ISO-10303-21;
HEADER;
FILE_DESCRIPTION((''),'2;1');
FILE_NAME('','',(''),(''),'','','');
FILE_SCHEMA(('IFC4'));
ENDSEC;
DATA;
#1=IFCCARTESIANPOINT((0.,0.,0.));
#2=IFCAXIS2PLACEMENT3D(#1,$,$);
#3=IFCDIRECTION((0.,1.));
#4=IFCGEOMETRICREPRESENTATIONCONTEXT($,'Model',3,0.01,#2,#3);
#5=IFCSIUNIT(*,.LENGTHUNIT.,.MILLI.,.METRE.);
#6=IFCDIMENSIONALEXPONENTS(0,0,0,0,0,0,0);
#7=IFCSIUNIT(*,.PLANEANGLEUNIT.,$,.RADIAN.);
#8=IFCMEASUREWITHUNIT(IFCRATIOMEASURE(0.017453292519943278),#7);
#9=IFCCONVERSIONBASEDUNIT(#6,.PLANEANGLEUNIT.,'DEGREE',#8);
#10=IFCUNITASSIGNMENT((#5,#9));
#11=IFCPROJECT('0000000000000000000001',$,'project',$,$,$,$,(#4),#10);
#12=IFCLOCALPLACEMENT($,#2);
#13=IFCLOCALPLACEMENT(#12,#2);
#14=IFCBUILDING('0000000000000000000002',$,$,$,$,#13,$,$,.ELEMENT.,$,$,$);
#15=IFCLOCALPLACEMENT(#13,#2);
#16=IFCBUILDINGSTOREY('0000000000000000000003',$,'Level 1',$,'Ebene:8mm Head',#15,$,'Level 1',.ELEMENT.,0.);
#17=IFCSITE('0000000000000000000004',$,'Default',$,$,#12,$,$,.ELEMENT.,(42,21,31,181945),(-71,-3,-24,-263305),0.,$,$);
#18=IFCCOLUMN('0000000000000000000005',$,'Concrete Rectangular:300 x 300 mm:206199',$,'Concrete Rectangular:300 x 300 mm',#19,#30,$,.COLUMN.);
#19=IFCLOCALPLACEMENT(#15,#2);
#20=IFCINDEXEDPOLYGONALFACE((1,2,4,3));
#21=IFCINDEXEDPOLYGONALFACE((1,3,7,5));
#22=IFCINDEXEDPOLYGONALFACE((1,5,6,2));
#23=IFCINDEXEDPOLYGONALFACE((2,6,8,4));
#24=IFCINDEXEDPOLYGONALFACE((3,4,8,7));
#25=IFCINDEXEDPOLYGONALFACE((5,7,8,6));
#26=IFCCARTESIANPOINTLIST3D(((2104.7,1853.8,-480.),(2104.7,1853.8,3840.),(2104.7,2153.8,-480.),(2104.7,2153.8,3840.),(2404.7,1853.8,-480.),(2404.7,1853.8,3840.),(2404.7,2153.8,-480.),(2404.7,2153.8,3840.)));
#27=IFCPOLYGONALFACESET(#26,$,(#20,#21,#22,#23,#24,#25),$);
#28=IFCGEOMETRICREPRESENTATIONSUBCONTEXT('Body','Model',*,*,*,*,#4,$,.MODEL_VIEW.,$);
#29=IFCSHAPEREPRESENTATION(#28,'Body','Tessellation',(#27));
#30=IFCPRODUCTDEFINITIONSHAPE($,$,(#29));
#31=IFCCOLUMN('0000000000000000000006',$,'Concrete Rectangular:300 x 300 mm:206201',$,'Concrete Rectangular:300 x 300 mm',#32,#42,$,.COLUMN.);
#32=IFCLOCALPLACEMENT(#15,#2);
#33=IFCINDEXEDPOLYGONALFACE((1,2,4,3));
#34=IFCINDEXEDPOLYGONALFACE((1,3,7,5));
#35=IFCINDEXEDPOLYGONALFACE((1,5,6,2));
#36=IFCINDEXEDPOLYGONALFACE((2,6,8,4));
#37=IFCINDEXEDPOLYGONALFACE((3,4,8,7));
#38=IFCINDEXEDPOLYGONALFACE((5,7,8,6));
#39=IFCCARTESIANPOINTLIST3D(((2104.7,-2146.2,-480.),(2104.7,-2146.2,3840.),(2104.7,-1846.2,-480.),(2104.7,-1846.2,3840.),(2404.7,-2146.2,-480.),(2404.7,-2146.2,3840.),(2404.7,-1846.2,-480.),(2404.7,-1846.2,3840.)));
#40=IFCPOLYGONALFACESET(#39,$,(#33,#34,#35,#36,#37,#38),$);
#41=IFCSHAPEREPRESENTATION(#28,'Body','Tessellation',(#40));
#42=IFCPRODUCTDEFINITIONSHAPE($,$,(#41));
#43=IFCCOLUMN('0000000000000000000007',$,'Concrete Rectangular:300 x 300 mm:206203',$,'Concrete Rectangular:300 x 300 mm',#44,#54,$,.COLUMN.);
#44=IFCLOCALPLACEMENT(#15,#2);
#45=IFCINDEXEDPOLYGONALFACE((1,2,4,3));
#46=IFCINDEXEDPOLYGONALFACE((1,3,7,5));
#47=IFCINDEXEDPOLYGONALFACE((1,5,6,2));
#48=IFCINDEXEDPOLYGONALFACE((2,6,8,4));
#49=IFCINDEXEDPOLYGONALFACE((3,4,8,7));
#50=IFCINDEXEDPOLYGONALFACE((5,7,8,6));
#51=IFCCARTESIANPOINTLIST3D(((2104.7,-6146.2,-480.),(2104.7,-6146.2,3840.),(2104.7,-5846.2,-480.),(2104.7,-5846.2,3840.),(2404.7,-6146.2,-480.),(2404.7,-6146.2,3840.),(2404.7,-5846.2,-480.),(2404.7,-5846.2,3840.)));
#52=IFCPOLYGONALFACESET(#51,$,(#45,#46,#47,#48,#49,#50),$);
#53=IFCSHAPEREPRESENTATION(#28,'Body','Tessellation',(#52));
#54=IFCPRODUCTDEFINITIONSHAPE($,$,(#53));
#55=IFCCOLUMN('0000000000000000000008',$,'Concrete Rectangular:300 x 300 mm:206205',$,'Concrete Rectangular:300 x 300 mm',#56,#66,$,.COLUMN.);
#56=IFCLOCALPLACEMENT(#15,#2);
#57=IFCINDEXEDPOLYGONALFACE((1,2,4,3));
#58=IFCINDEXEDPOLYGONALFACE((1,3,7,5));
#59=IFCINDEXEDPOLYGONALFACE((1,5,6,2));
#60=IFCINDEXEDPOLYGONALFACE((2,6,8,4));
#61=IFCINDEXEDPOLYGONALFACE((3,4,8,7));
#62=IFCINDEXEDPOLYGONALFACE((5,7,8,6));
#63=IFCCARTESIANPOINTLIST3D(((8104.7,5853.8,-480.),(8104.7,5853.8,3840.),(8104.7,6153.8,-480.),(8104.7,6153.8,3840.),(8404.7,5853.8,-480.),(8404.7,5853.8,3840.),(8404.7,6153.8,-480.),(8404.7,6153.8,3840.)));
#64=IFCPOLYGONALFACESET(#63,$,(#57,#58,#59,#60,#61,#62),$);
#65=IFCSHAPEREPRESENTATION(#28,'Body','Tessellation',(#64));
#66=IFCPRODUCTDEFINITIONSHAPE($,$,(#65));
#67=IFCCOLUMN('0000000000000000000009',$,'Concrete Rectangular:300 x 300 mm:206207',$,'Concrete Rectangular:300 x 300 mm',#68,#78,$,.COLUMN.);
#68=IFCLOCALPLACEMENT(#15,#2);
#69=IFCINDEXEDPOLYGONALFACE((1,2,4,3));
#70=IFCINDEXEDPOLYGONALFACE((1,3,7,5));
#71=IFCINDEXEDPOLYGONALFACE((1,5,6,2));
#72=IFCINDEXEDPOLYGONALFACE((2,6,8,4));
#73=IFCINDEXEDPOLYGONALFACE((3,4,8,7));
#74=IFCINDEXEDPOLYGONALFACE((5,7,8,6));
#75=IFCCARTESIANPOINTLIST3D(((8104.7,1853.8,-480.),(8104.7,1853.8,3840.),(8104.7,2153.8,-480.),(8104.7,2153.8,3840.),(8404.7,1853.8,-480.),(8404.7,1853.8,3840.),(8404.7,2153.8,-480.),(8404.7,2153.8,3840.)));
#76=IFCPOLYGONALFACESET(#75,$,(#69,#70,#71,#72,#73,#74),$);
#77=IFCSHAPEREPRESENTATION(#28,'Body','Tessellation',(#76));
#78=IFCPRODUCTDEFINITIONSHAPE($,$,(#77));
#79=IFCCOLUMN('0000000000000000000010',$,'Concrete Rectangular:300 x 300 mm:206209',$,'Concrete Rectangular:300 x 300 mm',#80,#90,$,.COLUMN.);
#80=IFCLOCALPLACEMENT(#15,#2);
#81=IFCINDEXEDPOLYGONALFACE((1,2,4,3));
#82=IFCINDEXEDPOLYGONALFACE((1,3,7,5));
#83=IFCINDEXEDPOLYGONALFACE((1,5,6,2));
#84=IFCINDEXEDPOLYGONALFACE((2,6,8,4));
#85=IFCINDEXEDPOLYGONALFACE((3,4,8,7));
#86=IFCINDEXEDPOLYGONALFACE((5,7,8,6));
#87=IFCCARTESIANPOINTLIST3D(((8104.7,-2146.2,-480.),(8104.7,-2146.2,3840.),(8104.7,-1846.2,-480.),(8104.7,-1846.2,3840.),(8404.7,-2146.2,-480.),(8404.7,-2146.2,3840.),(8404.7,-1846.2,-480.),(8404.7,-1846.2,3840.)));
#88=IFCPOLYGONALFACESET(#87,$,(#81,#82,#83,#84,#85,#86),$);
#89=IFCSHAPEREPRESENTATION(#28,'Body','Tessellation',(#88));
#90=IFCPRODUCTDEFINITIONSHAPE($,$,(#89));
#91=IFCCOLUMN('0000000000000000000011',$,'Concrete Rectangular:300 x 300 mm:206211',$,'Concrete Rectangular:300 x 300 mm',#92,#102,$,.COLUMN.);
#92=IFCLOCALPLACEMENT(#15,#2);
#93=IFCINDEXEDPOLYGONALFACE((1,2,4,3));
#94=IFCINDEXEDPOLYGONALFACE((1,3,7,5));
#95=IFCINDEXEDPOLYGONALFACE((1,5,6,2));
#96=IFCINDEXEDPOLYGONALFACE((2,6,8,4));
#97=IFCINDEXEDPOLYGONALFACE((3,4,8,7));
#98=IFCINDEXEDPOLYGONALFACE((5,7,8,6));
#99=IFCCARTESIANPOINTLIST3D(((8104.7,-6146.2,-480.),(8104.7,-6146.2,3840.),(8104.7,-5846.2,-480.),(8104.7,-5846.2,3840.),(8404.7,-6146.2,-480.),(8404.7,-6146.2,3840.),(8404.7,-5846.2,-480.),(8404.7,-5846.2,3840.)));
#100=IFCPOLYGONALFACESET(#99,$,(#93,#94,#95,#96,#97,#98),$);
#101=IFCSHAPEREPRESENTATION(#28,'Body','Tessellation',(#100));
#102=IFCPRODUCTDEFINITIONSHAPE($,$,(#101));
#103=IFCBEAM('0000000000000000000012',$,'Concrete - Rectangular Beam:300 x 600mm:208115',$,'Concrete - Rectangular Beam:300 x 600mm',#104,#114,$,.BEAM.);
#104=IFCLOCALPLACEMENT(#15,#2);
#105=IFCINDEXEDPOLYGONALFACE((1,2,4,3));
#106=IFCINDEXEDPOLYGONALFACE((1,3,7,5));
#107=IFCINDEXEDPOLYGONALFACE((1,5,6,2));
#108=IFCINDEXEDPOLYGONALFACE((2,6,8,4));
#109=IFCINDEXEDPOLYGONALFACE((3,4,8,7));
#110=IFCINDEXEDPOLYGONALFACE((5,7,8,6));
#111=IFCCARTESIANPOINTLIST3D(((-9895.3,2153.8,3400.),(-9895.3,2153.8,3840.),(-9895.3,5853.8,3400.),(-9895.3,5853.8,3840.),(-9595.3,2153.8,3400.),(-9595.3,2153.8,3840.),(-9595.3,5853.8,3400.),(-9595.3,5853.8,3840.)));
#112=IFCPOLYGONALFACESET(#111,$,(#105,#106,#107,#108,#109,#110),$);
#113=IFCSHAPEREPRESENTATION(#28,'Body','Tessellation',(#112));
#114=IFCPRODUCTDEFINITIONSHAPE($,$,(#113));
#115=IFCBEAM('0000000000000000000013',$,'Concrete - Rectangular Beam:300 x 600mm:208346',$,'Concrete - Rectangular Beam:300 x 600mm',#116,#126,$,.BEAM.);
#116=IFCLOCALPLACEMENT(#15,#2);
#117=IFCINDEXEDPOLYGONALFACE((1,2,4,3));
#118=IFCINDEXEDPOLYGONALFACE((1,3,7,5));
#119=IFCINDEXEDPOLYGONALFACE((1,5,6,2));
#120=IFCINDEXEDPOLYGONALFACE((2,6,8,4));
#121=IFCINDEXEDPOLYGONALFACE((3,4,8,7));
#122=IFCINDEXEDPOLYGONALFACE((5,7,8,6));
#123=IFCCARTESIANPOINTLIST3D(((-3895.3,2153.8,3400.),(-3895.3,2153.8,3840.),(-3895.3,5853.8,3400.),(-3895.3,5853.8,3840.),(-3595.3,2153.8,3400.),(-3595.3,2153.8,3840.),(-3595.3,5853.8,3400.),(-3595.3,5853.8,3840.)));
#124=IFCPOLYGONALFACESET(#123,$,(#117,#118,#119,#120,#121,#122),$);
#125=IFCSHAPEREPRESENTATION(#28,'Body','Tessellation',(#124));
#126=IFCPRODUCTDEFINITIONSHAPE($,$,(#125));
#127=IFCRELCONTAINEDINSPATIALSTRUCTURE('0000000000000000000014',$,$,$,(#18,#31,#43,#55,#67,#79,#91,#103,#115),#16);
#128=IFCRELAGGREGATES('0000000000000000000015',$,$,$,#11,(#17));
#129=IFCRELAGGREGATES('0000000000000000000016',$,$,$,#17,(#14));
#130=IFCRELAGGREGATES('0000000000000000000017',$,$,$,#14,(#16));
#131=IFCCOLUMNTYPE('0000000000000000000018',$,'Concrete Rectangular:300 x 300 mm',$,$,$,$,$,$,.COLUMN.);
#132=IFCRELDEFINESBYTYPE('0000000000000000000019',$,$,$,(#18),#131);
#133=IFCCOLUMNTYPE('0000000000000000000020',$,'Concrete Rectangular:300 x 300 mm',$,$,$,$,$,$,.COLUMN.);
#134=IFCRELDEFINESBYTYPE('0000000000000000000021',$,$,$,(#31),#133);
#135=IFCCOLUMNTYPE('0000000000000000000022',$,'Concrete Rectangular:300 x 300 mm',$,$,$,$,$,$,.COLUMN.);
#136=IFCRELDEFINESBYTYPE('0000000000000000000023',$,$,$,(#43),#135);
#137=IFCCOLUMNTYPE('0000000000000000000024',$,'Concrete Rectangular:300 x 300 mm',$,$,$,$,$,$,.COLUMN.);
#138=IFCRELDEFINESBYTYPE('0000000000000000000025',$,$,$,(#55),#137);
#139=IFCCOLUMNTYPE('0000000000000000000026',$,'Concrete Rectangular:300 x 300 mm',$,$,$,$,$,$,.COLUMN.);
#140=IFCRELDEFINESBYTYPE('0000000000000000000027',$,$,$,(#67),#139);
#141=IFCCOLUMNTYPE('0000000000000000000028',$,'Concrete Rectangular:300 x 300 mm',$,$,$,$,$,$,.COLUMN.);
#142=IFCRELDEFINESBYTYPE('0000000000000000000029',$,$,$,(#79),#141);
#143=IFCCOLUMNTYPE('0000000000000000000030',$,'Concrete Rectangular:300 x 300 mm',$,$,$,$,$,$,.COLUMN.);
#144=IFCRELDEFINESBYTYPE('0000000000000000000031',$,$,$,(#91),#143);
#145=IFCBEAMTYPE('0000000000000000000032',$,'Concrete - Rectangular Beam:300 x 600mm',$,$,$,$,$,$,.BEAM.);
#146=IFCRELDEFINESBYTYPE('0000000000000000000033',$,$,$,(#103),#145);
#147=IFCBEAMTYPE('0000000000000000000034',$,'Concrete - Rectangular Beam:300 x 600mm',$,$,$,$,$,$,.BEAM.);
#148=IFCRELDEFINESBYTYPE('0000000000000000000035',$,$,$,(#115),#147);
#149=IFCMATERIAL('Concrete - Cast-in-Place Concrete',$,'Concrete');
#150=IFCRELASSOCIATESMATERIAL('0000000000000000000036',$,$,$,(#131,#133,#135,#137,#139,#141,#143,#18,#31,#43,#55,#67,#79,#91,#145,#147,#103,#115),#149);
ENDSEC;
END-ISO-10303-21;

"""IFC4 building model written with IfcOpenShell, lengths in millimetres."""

from ifc_helpers import new_model, entity, si_unit, converted_unit, direction, frame, frame_2d, origin, origin_2d_with_axis, place, context, subcontext, project, spatial, polyline, segment, composite_curve, rectangle, outline, extrude, source, transform, mapped, material, material_profile, profile_set, profile_usage, type_object, type_shapes, element, save


model = new_model("IFC4")

# Units and contexts
model_context = context("Model", 3, precision=0.01, world=origin(), true_north=direction((0.0, 1.0)))
body_context = subcontext(model_context, "Body", "Model", "MODEL_VIEW")
ifc_project = project(units=[si_unit("LENGTHUNIT", "METRE", prefix="MILLI"), converted_unit("PLANEANGLEUNIT", "DEGREE", entity("IfcRatioMeasure", 0.017453292519943278), si_unit("PLANEANGLEUNIT", "RADIAN"), dimensions=[0, 0, 0, 0, 0, 0, 0])], contexts=[model_context])

# Site, building, storey
site_placement = place(None, origin())
site = spatial("IfcSite", under=ifc_project, at=site_placement, Name="Default", CompositionType="ELEMENT", RefLatitude=(42, 21, 31, 181945), RefLongitude=(-71, -3, -24, -263305), RefElevation=0.0)
building_placement = place(site_placement, origin())
building = spatial("IfcBuilding", under=site, at=building_placement, CompositionType="ELEMENT")
storey_placement = place(building_placement, origin())
storey = spatial("IfcBuildingStorey", under=building, at=storey_placement, Name="Level 1", ObjectType="Ebene:8mm Head", LongName="Level 1", CompositionType="ELEMENT", Elevation=0.0)

# Columns
ifc_material_1 = material(Name="Concrete - Cast-in-Place Concrete", Category="Concrete")
ifc_material_profile_1 = material_profile(ifc_material_1, outline(composite_curve([segment(polyline([(150.0, 150.0, 0.0), (150.0, -150.0, 0.0)]), True, "CONTINUOUS"), segment(polyline([(150.0, -150.0, 0.0), (-150.0, -150.0, 0.0)]), True, "CONTINUOUS"), segment(polyline([(-150.0, -150.0, 0.0), (-150.0, 150.0, 0.0)]), True, "CONTINUOUS"), segment(polyline([(-150.0, 150.0, 0.0), (150.0, 150.0, 0.0)]), True, "CONTINUOUS")], self_intersect=False), kind="CURVE"), Name="300 x 300 mm")
ifc_material_profile_2 = material_profile(ifc_material_1, outline(composite_curve([segment(polyline([(150.0, 150.0, 4000.0), (-150.0, 150.0, 4000.0)]), True, "CONTINUOUS"), segment(polyline([(-150.0, 150.0, 4000.0), (-150.0, -150.0, 4000.0)]), True, "CONTINUOUS"), segment(polyline([(-150.0, -150.0, 4000.0), (150.0, -150.0, 4000.0)]), True, "CONTINUOUS"), segment(polyline([(150.0, -150.0, 4000.0), (150.0, 150.0, 4000.0)]), True, "CONTINUOUS")], self_intersect=False), kind="CURVE"), Name="300 x 300 mm")
ifc_profile_set_1 = profile_set([ifc_material_profile_1, ifc_material_profile_2], Name="300 x 300 mm")
ifc_profile_usage_1 = profile_usage(ifc_profile_set_1)
column_type_1 = type_object("IfcColumnType", Name="Concrete Rectangular:300 x 300 mm", PredefinedType="COLUMN", material=ifc_profile_set_1)
shared_shape_1 = source(origin(), body_context, "Body", "SweptSolid", [
    extrude(rectangle(XDim=300.0, YDim=300.0, at=origin_2d_with_axis()), frame((2254.7, 2003.8, -480.0), z_axis=(0.0, 0.0, 1.0), x_axis=(0.0, -1.0, 0.0)), (0.0, 0.0, 1.0), 4320.0),
])
type_shapes(column_type_1, [shared_shape_1])
column_1_placement = place(storey_placement, origin())
element("IfcColumn", 1, at=column_1_placement, inside=storey, type_object=column_type_1, material=ifc_profile_usage_1, Name="Concrete Rectangular:300 x 300 mm:206199", ObjectType="Concrete Rectangular:300 x 300 mm", PredefinedType="COLUMN", context=body_context, shape_type="MappedRepresentation", body=[
    mapped(shared_shape_1, transform((0.0, 0.0, 0.0), scale=1.0)),
])
ifc_profile_usage_2 = profile_usage(ifc_profile_set_1)
column_type_2 = type_object("IfcColumnType", Name="Concrete Rectangular:300 x 300 mm", PredefinedType="COLUMN", material=ifc_profile_set_1)
shared_shape_2 = source(origin(), body_context, "Body", "SweptSolid", [
    extrude(rectangle(XDim=300.0, YDim=300.0, at=origin_2d_with_axis()), frame((2254.7, -1996.2, -480.0), z_axis=(0.0, 0.0, 1.0), x_axis=(0.0, -1.0, 0.0)), (0.0, 0.0, 1.0), 4320.0),
])
type_shapes(column_type_2, [shared_shape_2])
column_2_placement = place(storey_placement, origin())
element("IfcColumn", 2, at=column_2_placement, inside=storey, type_object=column_type_2, material=ifc_profile_usage_2, Name="Concrete Rectangular:300 x 300 mm:206201", ObjectType="Concrete Rectangular:300 x 300 mm", PredefinedType="COLUMN", context=body_context, shape_type="MappedRepresentation", body=[
    mapped(shared_shape_2, transform((0.0, 0.0, 0.0), scale=1.0)),
])
ifc_profile_usage_3 = profile_usage(ifc_profile_set_1)
column_type_3 = type_object("IfcColumnType", Name="Concrete Rectangular:300 x 300 mm", PredefinedType="COLUMN", material=ifc_profile_set_1)
shared_shape_3 = source(origin(), body_context, "Body", "SweptSolid", [
    extrude(rectangle(XDim=300.0, YDim=300.0, at=frame_2d((0.0, 0.0), x_axis=(1.0, 0.0))), frame((2254.7, -5996.2, -480.0), z_axis=(0.0, 0.0, 1.0), x_axis=(0.0, -1.0, 0.0)), (0.0, 0.0, 1.0), 4320.0),
])
type_shapes(column_type_3, [shared_shape_3])
column_3_placement = place(storey_placement, origin())
element("IfcColumn", 3, at=column_3_placement, inside=storey, type_object=column_type_3, material=ifc_profile_usage_3, Name="Concrete Rectangular:300 x 300 mm:206203", ObjectType="Concrete Rectangular:300 x 300 mm", PredefinedType="COLUMN", context=body_context, shape_type="MappedRepresentation", body=[
    mapped(shared_shape_3, transform((0.0, 0.0, 0.0), scale=1.0)),
])
ifc_profile_usage_4 = profile_usage(ifc_profile_set_1)
column_type_4 = type_object("IfcColumnType", Name="Concrete Rectangular:300 x 300 mm", PredefinedType="COLUMN", material=ifc_profile_set_1)
shared_shape_4 = source(origin(), body_context, "Body", "SweptSolid", [
    extrude(rectangle(XDim=300.0, YDim=300.0, at=frame_2d((0.0, 0.0), x_axis=(1.0, 0.0))), frame((8254.7, 6003.8, -480.0), z_axis=(0.0, 0.0, 1.0), x_axis=(0.0, -1.0, 0.0)), (0.0, 0.0, 1.0), 4320.0),
])
type_shapes(column_type_4, [shared_shape_4])
column_4_placement = place(storey_placement, origin())
element("IfcColumn", 4, at=column_4_placement, inside=storey, type_object=column_type_4, material=ifc_profile_usage_4, Name="Concrete Rectangular:300 x 300 mm:206205", ObjectType="Concrete Rectangular:300 x 300 mm", PredefinedType="COLUMN", context=body_context, shape_type="MappedRepresentation", body=[
    mapped(shared_shape_4, transform((0.0, 0.0, 0.0), scale=1.0)),
])
ifc_profile_usage_5 = profile_usage(ifc_profile_set_1)
column_type_5 = type_object("IfcColumnType", Name="Concrete Rectangular:300 x 300 mm", PredefinedType="COLUMN", material=ifc_profile_set_1)
shared_shape_5 = source(origin(), body_context, "Body", "SweptSolid", [
    extrude(rectangle(XDim=300.0, YDim=300.0, at=frame_2d((0.0, 0.0), x_axis=(1.0, 0.0))), frame((8254.7, 2003.8, -480.0), z_axis=(0.0, 0.0, 1.0), x_axis=(0.0, -1.0, 0.0)), (0.0, 0.0, 1.0), 4320.0),
])
type_shapes(column_type_5, [shared_shape_5])
column_5_placement = place(storey_placement, origin())
element("IfcColumn", 5, at=column_5_placement, inside=storey, type_object=column_type_5, material=ifc_profile_usage_5, Name="Concrete Rectangular:300 x 300 mm:206207", ObjectType="Concrete Rectangular:300 x 300 mm", PredefinedType="COLUMN", context=body_context, shape_type="MappedRepresentation", body=[
    mapped(shared_shape_5, transform((0.0, 0.0, 0.0), scale=1.0)),
])
ifc_profile_usage_6 = profile_usage(ifc_profile_set_1)
column_type_6 = type_object("IfcColumnType", Name="Concrete Rectangular:300 x 300 mm", PredefinedType="COLUMN", material=ifc_profile_set_1)
shared_shape_6 = source(origin(), body_context, "Body", "SweptSolid", [
    extrude(rectangle(XDim=300.0, YDim=300.0, at=frame_2d((0.0, 0.0), x_axis=(1.0, 0.0))), frame((8254.7, -1996.2, -480.0), z_axis=(0.0, 0.0, 1.0), x_axis=(0.0, -1.0, 0.0)), (0.0, 0.0, 1.0), 4320.0),
])
type_shapes(column_type_6, [shared_shape_6])
column_6_placement = place(storey_placement, origin())
element("IfcColumn", 6, at=column_6_placement, inside=storey, type_object=column_type_6, material=ifc_profile_usage_6, Name="Concrete Rectangular:300 x 300 mm:206209", ObjectType="Concrete Rectangular:300 x 300 mm", PredefinedType="COLUMN", context=body_context, shape_type="MappedRepresentation", body=[
    mapped(shared_shape_6, transform((0.0, 0.0, 0.0), scale=1.0)),
])
ifc_profile_usage_7 = profile_usage(ifc_profile_set_1)
column_type_7 = type_object("IfcColumnType", Name="Concrete Rectangular:300 x 300 mm", PredefinedType="COLUMN", material=ifc_profile_set_1)
shared_shape_7 = source(origin(), body_context, "Body", "SweptSolid", [
    extrude(rectangle(XDim=300.0, YDim=300.0, at=frame_2d((0.0, 0.0), x_axis=(1.0, 0.0))), frame((8254.7, -5996.2, -480.0), z_axis=(0.0, 0.0, 1.0), x_axis=(0.0, -1.0, 0.0)), (0.0, 0.0, 1.0), 4320.0),
])
type_shapes(column_type_7, [shared_shape_7])
column_7_placement = place(storey_placement, origin())
element("IfcColumn", 7, at=column_7_placement, inside=storey, type_object=column_type_7, material=ifc_profile_usage_7, Name="Concrete Rectangular:300 x 300 mm:206211", ObjectType="Concrete Rectangular:300 x 300 mm", PredefinedType="COLUMN", context=body_context, shape_type="MappedRepresentation", body=[
    mapped(shared_shape_7, transform((0.0, 0.0, 0.0), scale=1.0)),
])

# Beams
ifc_material_profile_3 = material_profile(ifc_material_1, outline(composite_curve([segment(polyline([(-150.0, -300.0, 0.0), (-150.0, 140.0, 0.0)]), True, "CONTINUOUS"), segment(polyline([(-150.0, 140.0, 0.0), (150.0, 140.0, 0.0)]), True, "CONTINUOUS"), segment(polyline([(150.0, 140.0, 0.0), (150.0, -300.0, 0.0)]), True, "CONTINUOUS"), segment(polyline([(150.0, -300.0, 0.0), (-150.0, -300.0, 0.0)]), True, "CONTINUOUS")], self_intersect=False), kind="CURVE"), Name="300 x 600mm")
ifc_material_profile_4 = material_profile(ifc_material_1, outline(composite_curve([segment(polyline([(1850.0, -150.0, -300.0), (1850.0, -150.0, 300.0)]), True, "CONTINUOUS"), segment(polyline([(1850.0, -150.0, 300.0), (-1850.0, -150.0, 300.0)]), True, "CONTINUOUS"), segment(polyline([(-1850.0, -150.0, 300.0), (-1850.0, -150.0, -300.0)]), True, "CONTINUOUS"), segment(polyline([(-1850.0, -150.0, -300.0), (1850.0, -150.0, -300.0)]), True, "CONTINUOUS")], self_intersect=False), kind="CURVE"), Name="300 x 600mm")
ifc_profile_set_2 = profile_set([ifc_material_profile_3, ifc_material_profile_4], Name="300 x 600mm")
ifc_profile_usage_8 = profile_usage(ifc_profile_set_2, cardinal=8)
beam_type_1 = type_object("IfcBeamType", Name="Concrete - Rectangular Beam:300 x 600mm", PredefinedType="BEAM", material=ifc_profile_set_2)
shared_shape_8 = source(origin(), body_context, "Body", "SweptSolid", [
    extrude(rectangle(XDim=440.0, YDim=300.0, at=frame_2d((0.0, 0.0), x_axis=(0.0, 1.0))), frame((-9745.3, 5853.8, 3620.0), z_axis=(0.0, -1.0, 0.0), x_axis=(-1.0, 0.0, 0.0)), (0.0, 0.0, 1.0), 3700.0),
])
type_shapes(beam_type_1, [shared_shape_8])
beam_1_placement = place(storey_placement, origin())
element("IfcBeam", 8, at=beam_1_placement, inside=storey, type_object=beam_type_1, material=ifc_profile_usage_8, Name="Concrete - Rectangular Beam:300 x 600mm:208115", ObjectType="Concrete - Rectangular Beam:300 x 600mm", PredefinedType="BEAM", context=body_context, shape_type="MappedRepresentation", body=[
    mapped(shared_shape_8, transform((0.0, 0.0, 0.0), scale=1.0)),
])
ifc_profile_usage_9 = profile_usage(ifc_profile_set_2, cardinal=8)
beam_type_2 = type_object("IfcBeamType", Name="Concrete - Rectangular Beam:300 x 600mm", PredefinedType="BEAM", material=ifc_profile_set_2)
shared_shape_9 = source(origin(), body_context, "Body", "SweptSolid", [
    extrude(rectangle(XDim=440.0, YDim=300.0, at=frame_2d((0.0, 0.0), x_axis=(0.0, 1.0))), frame((-3745.3, 5853.8, 3620.0), z_axis=(0.0, -1.0, 0.0), x_axis=(-1.0, 0.0, 0.0)), (0.0, 0.0, 1.0), 3700.0),
])
type_shapes(beam_type_2, [shared_shape_9])
beam_2_placement = place(storey_placement, origin())
element("IfcBeam", 9, at=beam_2_placement, inside=storey, type_object=beam_type_2, material=ifc_profile_usage_9, Name="Concrete - Rectangular Beam:300 x 600mm:208346", ObjectType="Concrete - Rectangular Beam:300 x 600mm", PredefinedType="BEAM", context=body_context, shape_type="MappedRepresentation", body=[
    mapped(shared_shape_9, transform((0.0, 0.0, 0.0), scale=1.0)),
])

save(model, "model.ifc")
